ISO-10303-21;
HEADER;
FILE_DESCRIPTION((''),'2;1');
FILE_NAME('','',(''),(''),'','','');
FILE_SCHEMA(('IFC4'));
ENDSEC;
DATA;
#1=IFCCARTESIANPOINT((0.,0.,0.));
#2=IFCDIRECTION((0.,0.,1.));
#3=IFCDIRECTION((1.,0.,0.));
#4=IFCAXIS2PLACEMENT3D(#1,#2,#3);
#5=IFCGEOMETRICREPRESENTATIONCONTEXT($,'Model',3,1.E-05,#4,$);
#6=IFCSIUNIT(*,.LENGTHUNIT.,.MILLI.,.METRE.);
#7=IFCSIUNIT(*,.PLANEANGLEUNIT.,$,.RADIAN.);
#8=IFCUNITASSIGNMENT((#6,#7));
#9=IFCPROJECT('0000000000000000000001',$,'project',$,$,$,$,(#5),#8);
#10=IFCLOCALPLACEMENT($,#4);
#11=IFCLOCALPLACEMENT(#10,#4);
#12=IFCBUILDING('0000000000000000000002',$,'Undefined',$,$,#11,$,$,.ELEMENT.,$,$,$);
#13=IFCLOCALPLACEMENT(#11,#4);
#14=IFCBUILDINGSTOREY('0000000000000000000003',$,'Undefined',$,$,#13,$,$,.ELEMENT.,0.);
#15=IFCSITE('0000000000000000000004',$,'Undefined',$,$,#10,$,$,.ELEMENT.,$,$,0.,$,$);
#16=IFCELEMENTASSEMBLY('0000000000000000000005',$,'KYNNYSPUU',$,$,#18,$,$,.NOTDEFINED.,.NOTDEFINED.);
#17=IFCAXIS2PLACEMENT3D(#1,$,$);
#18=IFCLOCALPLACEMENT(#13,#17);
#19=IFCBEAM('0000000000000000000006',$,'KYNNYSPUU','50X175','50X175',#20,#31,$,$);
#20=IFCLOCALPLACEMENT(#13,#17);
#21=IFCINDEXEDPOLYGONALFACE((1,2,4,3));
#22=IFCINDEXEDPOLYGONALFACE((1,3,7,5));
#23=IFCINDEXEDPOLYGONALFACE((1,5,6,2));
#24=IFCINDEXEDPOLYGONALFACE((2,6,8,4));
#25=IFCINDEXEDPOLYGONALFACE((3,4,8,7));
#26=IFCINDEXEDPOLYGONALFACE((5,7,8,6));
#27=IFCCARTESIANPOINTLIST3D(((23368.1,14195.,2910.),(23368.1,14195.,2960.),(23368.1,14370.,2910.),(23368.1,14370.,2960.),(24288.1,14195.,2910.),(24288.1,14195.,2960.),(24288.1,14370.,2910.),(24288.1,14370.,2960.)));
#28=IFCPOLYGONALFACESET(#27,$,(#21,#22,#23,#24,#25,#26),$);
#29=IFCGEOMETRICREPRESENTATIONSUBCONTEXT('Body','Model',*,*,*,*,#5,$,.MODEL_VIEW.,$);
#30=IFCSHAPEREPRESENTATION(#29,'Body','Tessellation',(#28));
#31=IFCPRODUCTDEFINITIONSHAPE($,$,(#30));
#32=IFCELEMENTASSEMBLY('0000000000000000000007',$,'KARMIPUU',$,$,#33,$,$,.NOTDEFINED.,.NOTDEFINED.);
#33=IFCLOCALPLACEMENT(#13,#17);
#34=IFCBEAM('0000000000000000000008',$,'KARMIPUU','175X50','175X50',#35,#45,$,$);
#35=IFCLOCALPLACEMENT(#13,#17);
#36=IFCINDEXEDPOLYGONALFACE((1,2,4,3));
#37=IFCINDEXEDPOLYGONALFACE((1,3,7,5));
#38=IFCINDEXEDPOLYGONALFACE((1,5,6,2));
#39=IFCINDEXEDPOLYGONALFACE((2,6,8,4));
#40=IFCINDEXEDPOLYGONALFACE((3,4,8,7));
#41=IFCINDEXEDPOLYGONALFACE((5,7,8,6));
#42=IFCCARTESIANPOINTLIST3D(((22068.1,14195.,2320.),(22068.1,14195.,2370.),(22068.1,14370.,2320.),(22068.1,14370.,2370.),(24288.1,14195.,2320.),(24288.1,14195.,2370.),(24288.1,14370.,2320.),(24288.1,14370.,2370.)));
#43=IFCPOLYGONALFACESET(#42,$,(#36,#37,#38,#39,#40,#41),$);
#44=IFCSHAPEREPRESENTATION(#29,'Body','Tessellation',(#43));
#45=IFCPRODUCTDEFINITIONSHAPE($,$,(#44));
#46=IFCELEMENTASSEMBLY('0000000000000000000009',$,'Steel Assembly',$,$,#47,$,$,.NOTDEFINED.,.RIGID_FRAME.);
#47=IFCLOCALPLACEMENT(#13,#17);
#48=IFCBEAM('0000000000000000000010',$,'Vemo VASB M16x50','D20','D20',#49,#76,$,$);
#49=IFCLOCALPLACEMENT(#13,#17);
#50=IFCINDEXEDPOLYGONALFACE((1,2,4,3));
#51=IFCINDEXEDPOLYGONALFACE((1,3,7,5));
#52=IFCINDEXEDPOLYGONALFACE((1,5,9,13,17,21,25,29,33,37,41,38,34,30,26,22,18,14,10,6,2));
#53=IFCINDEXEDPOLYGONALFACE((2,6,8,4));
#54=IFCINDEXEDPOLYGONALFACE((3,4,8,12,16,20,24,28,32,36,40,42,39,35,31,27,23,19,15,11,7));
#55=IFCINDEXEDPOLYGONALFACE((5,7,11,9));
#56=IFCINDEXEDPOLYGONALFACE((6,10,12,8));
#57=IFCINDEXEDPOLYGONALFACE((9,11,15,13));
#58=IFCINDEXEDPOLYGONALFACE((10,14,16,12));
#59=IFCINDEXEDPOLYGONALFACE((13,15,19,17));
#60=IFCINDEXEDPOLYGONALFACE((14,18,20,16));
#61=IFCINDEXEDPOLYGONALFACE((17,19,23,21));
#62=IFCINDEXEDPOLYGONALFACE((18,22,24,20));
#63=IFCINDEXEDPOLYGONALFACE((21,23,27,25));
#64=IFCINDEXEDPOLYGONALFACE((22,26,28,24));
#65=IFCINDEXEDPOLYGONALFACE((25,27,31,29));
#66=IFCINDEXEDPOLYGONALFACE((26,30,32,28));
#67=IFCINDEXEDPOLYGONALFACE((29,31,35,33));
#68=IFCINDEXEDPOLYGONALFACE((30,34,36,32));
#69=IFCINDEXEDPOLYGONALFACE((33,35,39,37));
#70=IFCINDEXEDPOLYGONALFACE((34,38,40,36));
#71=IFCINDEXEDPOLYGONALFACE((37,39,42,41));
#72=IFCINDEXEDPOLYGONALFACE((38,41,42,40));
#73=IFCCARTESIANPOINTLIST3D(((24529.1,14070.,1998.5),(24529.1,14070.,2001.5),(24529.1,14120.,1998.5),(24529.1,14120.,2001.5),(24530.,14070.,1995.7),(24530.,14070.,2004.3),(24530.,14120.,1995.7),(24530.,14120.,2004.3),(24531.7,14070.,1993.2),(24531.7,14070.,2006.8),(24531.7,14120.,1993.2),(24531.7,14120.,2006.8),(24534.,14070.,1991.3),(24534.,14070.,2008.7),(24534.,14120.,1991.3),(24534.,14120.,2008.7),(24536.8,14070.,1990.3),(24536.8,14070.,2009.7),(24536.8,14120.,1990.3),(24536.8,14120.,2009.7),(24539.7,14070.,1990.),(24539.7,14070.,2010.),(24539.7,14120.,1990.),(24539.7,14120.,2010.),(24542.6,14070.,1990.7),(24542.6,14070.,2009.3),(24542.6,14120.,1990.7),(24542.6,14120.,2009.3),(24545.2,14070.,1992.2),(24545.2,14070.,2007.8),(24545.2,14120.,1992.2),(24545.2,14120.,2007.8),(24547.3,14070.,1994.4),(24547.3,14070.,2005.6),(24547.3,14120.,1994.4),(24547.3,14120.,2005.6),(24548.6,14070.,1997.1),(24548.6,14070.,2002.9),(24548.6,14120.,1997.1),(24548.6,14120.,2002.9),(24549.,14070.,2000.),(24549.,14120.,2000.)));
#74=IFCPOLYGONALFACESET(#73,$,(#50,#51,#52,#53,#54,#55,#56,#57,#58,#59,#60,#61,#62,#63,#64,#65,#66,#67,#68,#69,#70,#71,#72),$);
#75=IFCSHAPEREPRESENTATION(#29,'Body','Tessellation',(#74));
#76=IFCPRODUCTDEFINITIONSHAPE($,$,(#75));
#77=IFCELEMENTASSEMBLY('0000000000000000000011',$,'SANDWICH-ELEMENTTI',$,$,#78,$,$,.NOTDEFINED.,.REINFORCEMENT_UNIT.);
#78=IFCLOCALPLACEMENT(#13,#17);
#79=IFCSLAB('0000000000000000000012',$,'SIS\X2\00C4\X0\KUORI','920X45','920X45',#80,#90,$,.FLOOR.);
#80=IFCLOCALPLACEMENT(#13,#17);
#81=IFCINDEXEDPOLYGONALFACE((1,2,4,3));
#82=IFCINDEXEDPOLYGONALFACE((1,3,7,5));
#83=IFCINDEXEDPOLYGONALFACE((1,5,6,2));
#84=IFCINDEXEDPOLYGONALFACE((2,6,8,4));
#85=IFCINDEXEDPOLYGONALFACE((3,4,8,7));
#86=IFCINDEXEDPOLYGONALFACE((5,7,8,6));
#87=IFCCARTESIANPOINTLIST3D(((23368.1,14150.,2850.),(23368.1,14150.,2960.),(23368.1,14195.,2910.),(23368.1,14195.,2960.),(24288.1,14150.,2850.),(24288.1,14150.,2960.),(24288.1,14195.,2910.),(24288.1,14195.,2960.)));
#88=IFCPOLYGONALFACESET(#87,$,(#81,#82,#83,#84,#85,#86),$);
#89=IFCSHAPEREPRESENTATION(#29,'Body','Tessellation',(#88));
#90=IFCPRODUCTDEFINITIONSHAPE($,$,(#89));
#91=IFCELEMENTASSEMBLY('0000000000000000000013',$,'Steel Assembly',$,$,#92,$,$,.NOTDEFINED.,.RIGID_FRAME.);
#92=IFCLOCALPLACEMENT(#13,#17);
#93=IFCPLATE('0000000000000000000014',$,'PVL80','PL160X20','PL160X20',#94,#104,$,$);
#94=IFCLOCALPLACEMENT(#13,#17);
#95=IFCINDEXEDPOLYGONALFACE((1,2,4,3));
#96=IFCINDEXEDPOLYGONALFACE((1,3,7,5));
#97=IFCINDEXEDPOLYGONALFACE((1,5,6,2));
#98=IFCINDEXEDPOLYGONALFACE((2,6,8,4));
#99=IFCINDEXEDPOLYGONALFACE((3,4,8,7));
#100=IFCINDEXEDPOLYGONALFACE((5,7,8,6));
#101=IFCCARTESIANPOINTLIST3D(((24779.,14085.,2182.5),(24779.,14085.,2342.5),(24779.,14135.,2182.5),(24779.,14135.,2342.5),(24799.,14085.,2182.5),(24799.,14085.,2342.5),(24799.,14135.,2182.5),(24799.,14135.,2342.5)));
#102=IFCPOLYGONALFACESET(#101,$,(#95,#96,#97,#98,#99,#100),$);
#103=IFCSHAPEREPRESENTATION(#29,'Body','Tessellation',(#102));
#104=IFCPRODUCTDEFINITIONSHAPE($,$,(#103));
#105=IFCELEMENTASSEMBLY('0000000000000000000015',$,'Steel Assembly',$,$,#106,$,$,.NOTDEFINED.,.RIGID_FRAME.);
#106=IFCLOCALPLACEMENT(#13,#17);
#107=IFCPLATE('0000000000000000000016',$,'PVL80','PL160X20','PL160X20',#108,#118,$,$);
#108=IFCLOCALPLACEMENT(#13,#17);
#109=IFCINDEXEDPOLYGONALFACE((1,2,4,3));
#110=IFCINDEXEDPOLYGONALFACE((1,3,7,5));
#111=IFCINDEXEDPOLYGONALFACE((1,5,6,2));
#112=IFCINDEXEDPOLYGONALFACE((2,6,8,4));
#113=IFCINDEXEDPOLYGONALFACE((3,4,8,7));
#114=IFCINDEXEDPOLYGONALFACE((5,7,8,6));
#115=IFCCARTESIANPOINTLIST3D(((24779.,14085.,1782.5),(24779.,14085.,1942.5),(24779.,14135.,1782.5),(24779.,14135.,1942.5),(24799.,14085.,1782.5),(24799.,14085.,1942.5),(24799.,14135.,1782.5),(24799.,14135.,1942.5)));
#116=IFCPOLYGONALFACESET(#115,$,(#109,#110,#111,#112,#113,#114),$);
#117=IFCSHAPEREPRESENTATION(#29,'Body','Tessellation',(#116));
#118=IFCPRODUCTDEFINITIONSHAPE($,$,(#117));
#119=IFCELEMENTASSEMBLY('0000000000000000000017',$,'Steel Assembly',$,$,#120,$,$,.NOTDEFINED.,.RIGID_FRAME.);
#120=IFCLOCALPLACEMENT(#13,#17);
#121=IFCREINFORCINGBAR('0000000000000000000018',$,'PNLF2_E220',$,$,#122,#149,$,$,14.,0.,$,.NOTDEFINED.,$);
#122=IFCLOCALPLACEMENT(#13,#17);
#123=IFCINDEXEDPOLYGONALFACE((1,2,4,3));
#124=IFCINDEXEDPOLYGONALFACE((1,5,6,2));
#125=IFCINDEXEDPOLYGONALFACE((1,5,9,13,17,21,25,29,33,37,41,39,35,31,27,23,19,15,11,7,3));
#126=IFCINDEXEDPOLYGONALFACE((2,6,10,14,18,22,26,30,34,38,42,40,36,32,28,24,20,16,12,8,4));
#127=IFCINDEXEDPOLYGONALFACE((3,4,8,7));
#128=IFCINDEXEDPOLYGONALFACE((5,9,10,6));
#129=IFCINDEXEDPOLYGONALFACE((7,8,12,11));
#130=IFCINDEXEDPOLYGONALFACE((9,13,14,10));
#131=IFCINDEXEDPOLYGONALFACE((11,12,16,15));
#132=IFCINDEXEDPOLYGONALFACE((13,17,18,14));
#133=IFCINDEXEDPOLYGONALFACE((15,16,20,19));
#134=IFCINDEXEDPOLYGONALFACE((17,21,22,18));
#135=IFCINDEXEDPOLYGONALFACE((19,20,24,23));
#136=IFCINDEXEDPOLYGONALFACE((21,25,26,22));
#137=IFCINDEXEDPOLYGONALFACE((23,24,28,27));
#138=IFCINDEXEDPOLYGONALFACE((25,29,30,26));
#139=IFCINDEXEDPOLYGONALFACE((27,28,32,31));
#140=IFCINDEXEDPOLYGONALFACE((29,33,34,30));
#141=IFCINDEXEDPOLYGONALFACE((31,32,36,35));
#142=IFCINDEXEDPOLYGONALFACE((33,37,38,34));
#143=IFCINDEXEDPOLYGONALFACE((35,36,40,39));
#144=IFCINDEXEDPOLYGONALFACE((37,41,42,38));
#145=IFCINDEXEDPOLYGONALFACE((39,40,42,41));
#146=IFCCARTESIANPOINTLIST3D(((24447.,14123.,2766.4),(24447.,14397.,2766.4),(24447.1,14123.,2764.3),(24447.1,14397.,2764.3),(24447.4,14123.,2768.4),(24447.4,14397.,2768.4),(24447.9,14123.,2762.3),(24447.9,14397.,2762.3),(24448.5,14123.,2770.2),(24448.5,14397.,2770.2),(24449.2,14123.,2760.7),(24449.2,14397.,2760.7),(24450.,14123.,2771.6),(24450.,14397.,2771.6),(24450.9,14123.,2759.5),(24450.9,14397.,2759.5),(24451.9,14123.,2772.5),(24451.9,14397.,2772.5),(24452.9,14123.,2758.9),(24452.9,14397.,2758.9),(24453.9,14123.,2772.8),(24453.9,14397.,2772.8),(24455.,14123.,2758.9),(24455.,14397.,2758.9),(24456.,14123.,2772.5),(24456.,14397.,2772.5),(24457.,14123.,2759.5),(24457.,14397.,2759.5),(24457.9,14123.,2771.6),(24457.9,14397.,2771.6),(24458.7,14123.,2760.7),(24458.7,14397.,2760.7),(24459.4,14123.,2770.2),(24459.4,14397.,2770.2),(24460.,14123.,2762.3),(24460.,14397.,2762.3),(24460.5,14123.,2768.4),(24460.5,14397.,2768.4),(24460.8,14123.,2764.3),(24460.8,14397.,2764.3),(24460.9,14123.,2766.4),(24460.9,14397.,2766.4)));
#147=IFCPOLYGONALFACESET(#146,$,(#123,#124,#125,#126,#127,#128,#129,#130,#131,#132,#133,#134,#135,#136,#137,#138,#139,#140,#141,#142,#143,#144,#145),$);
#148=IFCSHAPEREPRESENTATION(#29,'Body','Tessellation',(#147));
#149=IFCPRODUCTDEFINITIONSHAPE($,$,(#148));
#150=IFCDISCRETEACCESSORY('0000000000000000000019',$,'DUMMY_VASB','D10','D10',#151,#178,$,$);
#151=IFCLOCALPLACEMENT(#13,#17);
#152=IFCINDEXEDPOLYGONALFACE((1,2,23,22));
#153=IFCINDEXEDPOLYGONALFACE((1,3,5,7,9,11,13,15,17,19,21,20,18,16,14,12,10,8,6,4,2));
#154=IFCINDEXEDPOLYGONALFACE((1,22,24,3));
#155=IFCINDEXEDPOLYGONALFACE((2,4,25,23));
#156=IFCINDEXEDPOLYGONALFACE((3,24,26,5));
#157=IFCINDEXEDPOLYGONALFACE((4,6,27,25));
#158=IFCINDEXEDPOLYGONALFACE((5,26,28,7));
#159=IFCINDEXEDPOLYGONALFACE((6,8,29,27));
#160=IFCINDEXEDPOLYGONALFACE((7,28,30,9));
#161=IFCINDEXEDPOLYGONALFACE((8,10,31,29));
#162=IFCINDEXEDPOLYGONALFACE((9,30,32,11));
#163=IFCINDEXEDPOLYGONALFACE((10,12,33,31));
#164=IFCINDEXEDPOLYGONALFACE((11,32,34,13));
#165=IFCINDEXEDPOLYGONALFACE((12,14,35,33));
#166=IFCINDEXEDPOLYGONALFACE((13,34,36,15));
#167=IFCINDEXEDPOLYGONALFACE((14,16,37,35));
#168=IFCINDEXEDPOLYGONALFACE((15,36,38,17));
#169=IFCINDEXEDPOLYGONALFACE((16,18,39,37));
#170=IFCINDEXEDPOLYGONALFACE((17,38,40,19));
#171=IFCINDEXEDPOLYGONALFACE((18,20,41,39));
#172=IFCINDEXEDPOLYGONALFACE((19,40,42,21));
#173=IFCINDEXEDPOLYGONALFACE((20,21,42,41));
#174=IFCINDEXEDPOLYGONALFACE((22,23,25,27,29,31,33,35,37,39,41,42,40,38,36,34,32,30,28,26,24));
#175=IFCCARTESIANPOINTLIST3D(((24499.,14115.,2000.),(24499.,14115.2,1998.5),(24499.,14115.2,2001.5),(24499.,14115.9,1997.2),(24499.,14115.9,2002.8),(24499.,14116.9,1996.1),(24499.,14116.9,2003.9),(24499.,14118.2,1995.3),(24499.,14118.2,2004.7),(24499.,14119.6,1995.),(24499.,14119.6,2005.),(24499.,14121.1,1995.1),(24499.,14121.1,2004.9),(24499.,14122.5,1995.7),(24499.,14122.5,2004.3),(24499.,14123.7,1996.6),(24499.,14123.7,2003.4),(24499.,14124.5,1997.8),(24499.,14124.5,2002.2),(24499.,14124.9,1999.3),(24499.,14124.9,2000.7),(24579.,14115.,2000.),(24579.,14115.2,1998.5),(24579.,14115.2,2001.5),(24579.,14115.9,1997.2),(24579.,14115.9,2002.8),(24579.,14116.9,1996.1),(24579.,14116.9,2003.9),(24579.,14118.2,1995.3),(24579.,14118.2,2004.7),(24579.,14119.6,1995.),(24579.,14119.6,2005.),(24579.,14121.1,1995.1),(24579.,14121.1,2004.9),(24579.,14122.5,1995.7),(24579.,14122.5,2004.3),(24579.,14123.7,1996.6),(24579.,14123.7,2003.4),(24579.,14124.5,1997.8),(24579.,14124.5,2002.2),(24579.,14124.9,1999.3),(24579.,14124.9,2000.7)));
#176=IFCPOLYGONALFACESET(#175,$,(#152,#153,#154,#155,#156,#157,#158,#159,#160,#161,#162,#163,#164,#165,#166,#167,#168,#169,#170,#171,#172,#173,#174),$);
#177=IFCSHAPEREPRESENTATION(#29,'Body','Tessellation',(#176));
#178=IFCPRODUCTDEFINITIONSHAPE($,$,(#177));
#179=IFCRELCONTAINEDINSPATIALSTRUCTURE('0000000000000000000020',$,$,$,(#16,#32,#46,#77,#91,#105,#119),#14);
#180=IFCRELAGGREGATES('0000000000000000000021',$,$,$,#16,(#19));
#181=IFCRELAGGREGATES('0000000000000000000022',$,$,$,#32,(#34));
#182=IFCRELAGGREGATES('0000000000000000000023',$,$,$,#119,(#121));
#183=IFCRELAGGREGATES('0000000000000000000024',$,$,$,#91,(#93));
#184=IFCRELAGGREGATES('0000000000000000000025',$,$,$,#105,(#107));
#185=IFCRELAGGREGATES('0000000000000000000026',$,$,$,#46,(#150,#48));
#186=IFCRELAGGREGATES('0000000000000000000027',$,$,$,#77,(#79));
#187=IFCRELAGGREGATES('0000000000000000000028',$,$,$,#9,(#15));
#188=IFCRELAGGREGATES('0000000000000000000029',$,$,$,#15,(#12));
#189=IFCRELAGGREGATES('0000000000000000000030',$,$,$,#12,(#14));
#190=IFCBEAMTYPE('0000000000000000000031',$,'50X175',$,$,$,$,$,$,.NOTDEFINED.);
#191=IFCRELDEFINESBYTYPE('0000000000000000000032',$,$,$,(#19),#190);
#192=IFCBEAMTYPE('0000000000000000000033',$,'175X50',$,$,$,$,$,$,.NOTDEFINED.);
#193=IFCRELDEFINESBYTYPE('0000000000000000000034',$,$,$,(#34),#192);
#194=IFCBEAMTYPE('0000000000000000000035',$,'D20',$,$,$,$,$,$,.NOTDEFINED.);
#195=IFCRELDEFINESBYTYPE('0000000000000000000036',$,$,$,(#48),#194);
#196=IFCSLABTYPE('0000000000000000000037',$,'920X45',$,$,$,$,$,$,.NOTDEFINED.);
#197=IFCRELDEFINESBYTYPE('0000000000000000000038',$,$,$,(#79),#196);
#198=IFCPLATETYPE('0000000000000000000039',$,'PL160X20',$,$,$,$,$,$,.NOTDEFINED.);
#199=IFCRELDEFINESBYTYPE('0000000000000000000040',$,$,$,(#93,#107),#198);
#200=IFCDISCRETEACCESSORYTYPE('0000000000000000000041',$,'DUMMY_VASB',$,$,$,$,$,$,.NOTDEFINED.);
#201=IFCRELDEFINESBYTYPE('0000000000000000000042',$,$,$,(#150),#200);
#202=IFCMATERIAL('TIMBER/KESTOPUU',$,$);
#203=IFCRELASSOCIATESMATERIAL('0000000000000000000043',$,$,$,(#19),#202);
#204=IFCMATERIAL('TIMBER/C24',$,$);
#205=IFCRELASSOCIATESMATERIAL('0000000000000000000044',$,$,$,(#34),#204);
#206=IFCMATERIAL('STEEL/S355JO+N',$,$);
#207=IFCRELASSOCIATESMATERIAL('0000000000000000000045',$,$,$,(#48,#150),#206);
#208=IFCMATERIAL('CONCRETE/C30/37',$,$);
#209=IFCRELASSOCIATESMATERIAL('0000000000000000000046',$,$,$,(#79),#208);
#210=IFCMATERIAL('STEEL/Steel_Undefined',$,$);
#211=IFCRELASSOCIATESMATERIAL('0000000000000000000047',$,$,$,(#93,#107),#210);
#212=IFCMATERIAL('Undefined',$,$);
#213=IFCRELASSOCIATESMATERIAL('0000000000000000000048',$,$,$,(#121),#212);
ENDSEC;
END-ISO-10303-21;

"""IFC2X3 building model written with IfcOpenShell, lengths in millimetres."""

from ifc_helpers import new_model, entity, si_unit, frame, origin_with_axes, origin_2d_with_axis, place, context, subcontext, project, spatial, polyline, rectangle, circle, outline, extrude, source, transform, mapped, material, type_object, element, aggregate, save


model = new_model("IFC2X3")

# Units and contexts
model_context = context("Model", 3, precision=1e-05, world=origin_with_axes())
body_context = subcontext(model_context, "Body", "Model", "MODEL_VIEW")
ifc_project = project(units=[si_unit("LENGTHUNIT", "METRE", prefix="MILLI"), si_unit("PLANEANGLEUNIT", "RADIAN")], contexts=[model_context])

# Site, building, storey
site_placement = place(None, origin_with_axes())
site = spatial("IfcSite", under=ifc_project, at=site_placement, Name="Undefined", CompositionType="ELEMENT", RefElevation=0.0)
building_placement = place(site_placement, origin_with_axes())
building = spatial("IfcBuilding", under=site, at=building_placement, Name="Undefined", CompositionType="ELEMENT")
storey_placement = place(building_placement, origin_with_axes())
storey = spatial("IfcBuildingStorey", under=building, at=storey_placement, Name="Undefined", CompositionType="ELEMENT", Elevation=0.0)

# Element assemblies, beams
assembly_1_placement = place(storey_placement, origin_with_axes())
assembly_1 = element("IfcElementAssembly", 1, at=assembly_1_placement, inside=storey, Name="KYNNYSPUU", AssemblyPlace="NOTDEFINED", PredefinedType="NOTDEFINED")
ifc_material_1 = material(Name="TIMBER/KESTOPUU")
beam_type_1 = type_object("IfcBeamType", Name="50X175", PredefinedType="NOTDEFINED")
beam_1_placement = place(assembly_1_placement, frame((23368.1, 14282.5, 2935.0), z_axis=(0.0, 0.0, 1.0), x_axis=(1.0, 0.0, 0.0)))
beam_1 = element("IfcBeam", 2, at=beam_1_placement, type_object=beam_type_1, material=ifc_material_1, Name="KYNNYSPUU", Description="50X175", ObjectType="50X175", context=body_context, shape_type="SweptSolid", body=[
    extrude(rectangle(XDim=175.0, YDim=50.0, at=origin_2d_with_axis()), frame((920.0, 0.0, 0.0), z_axis=(-1.0, 0.0, 0.0), x_axis=(0.0, -1.0, 0.0)), (0.0, 0.0, 1.0), 920.0),
])
aggregate(assembly_1, [beam_1])
assembly_2_placement = place(storey_placement, origin_with_axes())
assembly_2 = element("IfcElementAssembly", 3, at=assembly_2_placement, inside=storey, Name="KARMIPUU", AssemblyPlace="NOTDEFINED", PredefinedType="NOTDEFINED")
ifc_material_2 = material(Name="TIMBER/C24")
beam_type_2 = type_object("IfcBeamType", Name="175X50", PredefinedType="NOTDEFINED")
beam_2_placement = place(assembly_2_placement, frame((24288.1, 14282.5, 2345.0), z_axis=(0.0, -1.0, 0.0), x_axis=(-1.0, 0.0, 0.0)))
beam_2 = element("IfcBeam", 4, at=beam_2_placement, type_object=beam_type_2, material=ifc_material_2, Name="KARMIPUU", Description="175X50", ObjectType="175X50", context=body_context, shape_type="SweptSolid", body=[
    extrude(rectangle(XDim=50.0, YDim=175.0, at=origin_2d_with_axis()), frame((2220.0, 0.0, 0.0), z_axis=(-1.0, 0.0, 0.0), x_axis=(0.0, -1.0, 0.0)), (0.0, 0.0, 1.0), 2220.0),
])
aggregate(assembly_2, [beam_2])
assembly_3_placement = place(storey_placement, origin_with_axes())
assembly_3 = element("IfcElementAssembly", 5, at=assembly_3_placement, inside=storey, Name="Steel Assembly", AssemblyPlace="NOTDEFINED", PredefinedType="RIGID_FRAME")
ifc_material_3 = material(Name="STEEL/S355JO+N")
beam_type_3 = type_object("IfcBeamType", Name="D20", PredefinedType="NOTDEFINED")
beam_3_placement = place(assembly_3_placement, frame((24539.0, 14070.0, 2000.0), z_axis=(0.0, 0.0, 1.0), x_axis=(0.0, 1.0, 0.0)))
beam_3 = element("IfcBeam", 6, at=beam_3_placement, type_object=beam_type_3, material=ifc_material_3, Name="Vemo VASB M16x50", Description="D20", ObjectType="D20", context=body_context, shape_type="SweptSolid", body=[
    extrude(circle(Radius=10.0, at=origin_2d_with_axis()), frame((50.0, 0.0, 0.0), z_axis=(-1.0, 0.0, 0.0), x_axis=(0.0, -1.0, 0.0)), (0.0, 0.0, 1.0), 50.0),
])

# Element assembly, slab
assembly_4_placement = place(storey_placement, origin_with_axes())
assembly_4 = element("IfcElementAssembly", 7, at=assembly_4_placement, inside=storey, Name="SANDWICH-ELEMENTTI", AssemblyPlace="NOTDEFINED", PredefinedType="REINFORCEMENT_UNIT")
ifc_material_4 = material(Name="CONCRETE/C30/37")
slab_type = type_object("IfcSlabType", Name="920X45", PredefinedType="NOTDEFINED")
slab_placement = place(assembly_4_placement, frame((23828.1, 14195.0, 2960.0), z_axis=(1.0, 0.0, 0.0), x_axis=(0.0, -1.0, 0.0)))
slab = element("IfcSlab", 8, at=slab_placement, type_object=slab_type, material=ifc_material_4, Name="SISÄKUORI", Description="920X45", ObjectType="920X45", PredefinedType="FLOOR", context=body_context, shape_type="SweptSolid", body=[
    extrude(outline(polyline([(0.0, 0.0), (45.0, 0.0), (45.0, 110.0), (0.0, 50.0), (0.0, 0.0)])), frame((0.0, 0.0, -460.0), z_axis=(0.0, 0.0, 1.0), x_axis=(1.0, 0.0, 0.0)), (0.0, 0.0, 1.0), 920.0),
])

# Element assemblies, plates
assembly_5_placement = place(storey_placement, origin_with_axes())
assembly_5 = element("IfcElementAssembly", 9, at=assembly_5_placement, inside=storey, Name="Steel Assembly", AssemblyPlace="NOTDEFINED", PredefinedType="RIGID_FRAME")
ifc_material_5 = material(Name="STEEL/Steel_Undefined")
plate_type = type_object("IfcPlateType", Name="PL160X20", PredefinedType="NOTDEFINED")
plate_1_placement = place(assembly_5_placement, frame((24799.0, 14135.0, 2262.5), z_axis=(0.0, 0.0, -1.0), x_axis=(0.0, -1.0, 0.0)))
plate_1 = element("IfcPlate", 10, at=plate_1_placement, type_object=plate_type, material=ifc_material_5, Name="PVL80", Description="PL160X20", ObjectType="PL160X20", context=body_context, shape_type="SweptSolid", body=[
    extrude(outline(polyline([(0.0, 0.0), (50.0, 0.0), (50.0, 20.0), (0.0, 20.0), (0.0, 0.0)])), frame((0.0, 0.0, -80.0), z_axis=(0.0, 0.0, 1.0), x_axis=(1.0, 0.0, 0.0)), (0.0, 0.0, 1.0), 160.0),
])
assembly_6_placement = place(storey_placement, origin_with_axes())
assembly_6 = element("IfcElementAssembly", 11, at=assembly_6_placement, inside=storey, Name="Steel Assembly", AssemblyPlace="NOTDEFINED", PredefinedType="RIGID_FRAME")
plate_2_placement = place(assembly_6_placement, frame((24799.0, 14135.0, 1862.5), z_axis=(0.0, 0.0, -1.0), x_axis=(0.0, -1.0, 0.0)))
plate_2 = element("IfcPlate", 12, at=plate_2_placement, type_object=plate_type, material=ifc_material_5, Name="PVL80", Description="PL160X20", ObjectType="PL160X20", context=body_context, shape_type="SweptSolid", body=[
    extrude(outline(polyline([(0.0, 0.0), (50.0, 0.0), (50.0, 20.0), (0.0, 20.0), (0.0, 0.0)])), frame((0.0, 0.0, -80.0), z_axis=(0.0, 0.0, 1.0), x_axis=(1.0, 0.0, 0.0)), (0.0, 0.0, 1.0), 160.0),
])

# Element assembly, reinforcing bar
assembly_7_placement = place(storey_placement, origin_with_axes())
assembly_7 = element("IfcElementAssembly", 13, at=assembly_7_placement, inside=storey, Name="Steel Assembly", AssemblyPlace="NOTDEFINED", PredefinedType="RIGID_FRAME")
ifc_material_6 = material(Name="Undefined")
shared_shape_1 = source(origin_with_axes(), body_context, "Body", "AdvancedSweptSolid", [
    entity("IfcSweptDiskSolid", entity("IfcTrimmedCurve", entity("IfcLine", entity("IfcCartesianPoint", [0.0, 0.0, 0.0]), entity("IfcVector", entity("IfcDirection", [1.0, 0.0, 0.0]), 1.0)), [entity("IfcParameterValue", 0.0)], [entity("IfcParameterValue", 273.999267)], True, "PARAMETER"), 7.0, None, 0.0, 274.0),
])
reinforcing_bar_1_placement = place(assembly_7_placement, frame((24453.9, 14123.0, 2765.8), z_axis=(0.0, 0.0, 1.0), x_axis=(0.0, 1.0, 0.0)))
reinforcing_bar_1 = element("IfcReinforcingBar", 14, at=reinforcing_bar_1_placement, material=ifc_material_6, Name="PNLF2_E220", BarRole="NOTDEFINED", CrossSectionArea=0.0, NominalDiameter=14.0, context=body_context, shape_type="MappedRepresentation", body=[
    mapped(shared_shape_1, transform((0.0, 0.0, 0.0))),
])
aggregate(assembly_7, [reinforcing_bar_1])

aggregate(assembly_5, [plate_1])
aggregate(assembly_6, [plate_2])

# Discrete accessory
discrete_accessory_type = type_object("IfcDiscreteAccessoryType", Name="DUMMY_VASB")
discrete_accessory_placement = place(assembly_3_placement, frame((24499.0, 14120.0, 2000.0), z_axis=(0.0, 0.0, 1.0), x_axis=(1.0, 0.0, 0.0)))
discrete_accessory = element("IfcDiscreteAccessory", 15, at=discrete_accessory_placement, type_object=discrete_accessory_type, material=ifc_material_3, Name="DUMMY_VASB", Description="D10", ObjectType="D10", context=body_context, shape_type="SweptSolid", body=[
    extrude(circle(Radius=5.0, at=origin_2d_with_axis()), frame((80.0, 0.0, 0.0), z_axis=(-1.0, 0.0, 0.0), x_axis=(0.0, -1.0, 0.0)), (0.0, 0.0, 1.0), 80.0),
])
aggregate(assembly_3, [discrete_accessory, beam_3])

aggregate(assembly_4, [slab])

save(model, "model.ifc")
